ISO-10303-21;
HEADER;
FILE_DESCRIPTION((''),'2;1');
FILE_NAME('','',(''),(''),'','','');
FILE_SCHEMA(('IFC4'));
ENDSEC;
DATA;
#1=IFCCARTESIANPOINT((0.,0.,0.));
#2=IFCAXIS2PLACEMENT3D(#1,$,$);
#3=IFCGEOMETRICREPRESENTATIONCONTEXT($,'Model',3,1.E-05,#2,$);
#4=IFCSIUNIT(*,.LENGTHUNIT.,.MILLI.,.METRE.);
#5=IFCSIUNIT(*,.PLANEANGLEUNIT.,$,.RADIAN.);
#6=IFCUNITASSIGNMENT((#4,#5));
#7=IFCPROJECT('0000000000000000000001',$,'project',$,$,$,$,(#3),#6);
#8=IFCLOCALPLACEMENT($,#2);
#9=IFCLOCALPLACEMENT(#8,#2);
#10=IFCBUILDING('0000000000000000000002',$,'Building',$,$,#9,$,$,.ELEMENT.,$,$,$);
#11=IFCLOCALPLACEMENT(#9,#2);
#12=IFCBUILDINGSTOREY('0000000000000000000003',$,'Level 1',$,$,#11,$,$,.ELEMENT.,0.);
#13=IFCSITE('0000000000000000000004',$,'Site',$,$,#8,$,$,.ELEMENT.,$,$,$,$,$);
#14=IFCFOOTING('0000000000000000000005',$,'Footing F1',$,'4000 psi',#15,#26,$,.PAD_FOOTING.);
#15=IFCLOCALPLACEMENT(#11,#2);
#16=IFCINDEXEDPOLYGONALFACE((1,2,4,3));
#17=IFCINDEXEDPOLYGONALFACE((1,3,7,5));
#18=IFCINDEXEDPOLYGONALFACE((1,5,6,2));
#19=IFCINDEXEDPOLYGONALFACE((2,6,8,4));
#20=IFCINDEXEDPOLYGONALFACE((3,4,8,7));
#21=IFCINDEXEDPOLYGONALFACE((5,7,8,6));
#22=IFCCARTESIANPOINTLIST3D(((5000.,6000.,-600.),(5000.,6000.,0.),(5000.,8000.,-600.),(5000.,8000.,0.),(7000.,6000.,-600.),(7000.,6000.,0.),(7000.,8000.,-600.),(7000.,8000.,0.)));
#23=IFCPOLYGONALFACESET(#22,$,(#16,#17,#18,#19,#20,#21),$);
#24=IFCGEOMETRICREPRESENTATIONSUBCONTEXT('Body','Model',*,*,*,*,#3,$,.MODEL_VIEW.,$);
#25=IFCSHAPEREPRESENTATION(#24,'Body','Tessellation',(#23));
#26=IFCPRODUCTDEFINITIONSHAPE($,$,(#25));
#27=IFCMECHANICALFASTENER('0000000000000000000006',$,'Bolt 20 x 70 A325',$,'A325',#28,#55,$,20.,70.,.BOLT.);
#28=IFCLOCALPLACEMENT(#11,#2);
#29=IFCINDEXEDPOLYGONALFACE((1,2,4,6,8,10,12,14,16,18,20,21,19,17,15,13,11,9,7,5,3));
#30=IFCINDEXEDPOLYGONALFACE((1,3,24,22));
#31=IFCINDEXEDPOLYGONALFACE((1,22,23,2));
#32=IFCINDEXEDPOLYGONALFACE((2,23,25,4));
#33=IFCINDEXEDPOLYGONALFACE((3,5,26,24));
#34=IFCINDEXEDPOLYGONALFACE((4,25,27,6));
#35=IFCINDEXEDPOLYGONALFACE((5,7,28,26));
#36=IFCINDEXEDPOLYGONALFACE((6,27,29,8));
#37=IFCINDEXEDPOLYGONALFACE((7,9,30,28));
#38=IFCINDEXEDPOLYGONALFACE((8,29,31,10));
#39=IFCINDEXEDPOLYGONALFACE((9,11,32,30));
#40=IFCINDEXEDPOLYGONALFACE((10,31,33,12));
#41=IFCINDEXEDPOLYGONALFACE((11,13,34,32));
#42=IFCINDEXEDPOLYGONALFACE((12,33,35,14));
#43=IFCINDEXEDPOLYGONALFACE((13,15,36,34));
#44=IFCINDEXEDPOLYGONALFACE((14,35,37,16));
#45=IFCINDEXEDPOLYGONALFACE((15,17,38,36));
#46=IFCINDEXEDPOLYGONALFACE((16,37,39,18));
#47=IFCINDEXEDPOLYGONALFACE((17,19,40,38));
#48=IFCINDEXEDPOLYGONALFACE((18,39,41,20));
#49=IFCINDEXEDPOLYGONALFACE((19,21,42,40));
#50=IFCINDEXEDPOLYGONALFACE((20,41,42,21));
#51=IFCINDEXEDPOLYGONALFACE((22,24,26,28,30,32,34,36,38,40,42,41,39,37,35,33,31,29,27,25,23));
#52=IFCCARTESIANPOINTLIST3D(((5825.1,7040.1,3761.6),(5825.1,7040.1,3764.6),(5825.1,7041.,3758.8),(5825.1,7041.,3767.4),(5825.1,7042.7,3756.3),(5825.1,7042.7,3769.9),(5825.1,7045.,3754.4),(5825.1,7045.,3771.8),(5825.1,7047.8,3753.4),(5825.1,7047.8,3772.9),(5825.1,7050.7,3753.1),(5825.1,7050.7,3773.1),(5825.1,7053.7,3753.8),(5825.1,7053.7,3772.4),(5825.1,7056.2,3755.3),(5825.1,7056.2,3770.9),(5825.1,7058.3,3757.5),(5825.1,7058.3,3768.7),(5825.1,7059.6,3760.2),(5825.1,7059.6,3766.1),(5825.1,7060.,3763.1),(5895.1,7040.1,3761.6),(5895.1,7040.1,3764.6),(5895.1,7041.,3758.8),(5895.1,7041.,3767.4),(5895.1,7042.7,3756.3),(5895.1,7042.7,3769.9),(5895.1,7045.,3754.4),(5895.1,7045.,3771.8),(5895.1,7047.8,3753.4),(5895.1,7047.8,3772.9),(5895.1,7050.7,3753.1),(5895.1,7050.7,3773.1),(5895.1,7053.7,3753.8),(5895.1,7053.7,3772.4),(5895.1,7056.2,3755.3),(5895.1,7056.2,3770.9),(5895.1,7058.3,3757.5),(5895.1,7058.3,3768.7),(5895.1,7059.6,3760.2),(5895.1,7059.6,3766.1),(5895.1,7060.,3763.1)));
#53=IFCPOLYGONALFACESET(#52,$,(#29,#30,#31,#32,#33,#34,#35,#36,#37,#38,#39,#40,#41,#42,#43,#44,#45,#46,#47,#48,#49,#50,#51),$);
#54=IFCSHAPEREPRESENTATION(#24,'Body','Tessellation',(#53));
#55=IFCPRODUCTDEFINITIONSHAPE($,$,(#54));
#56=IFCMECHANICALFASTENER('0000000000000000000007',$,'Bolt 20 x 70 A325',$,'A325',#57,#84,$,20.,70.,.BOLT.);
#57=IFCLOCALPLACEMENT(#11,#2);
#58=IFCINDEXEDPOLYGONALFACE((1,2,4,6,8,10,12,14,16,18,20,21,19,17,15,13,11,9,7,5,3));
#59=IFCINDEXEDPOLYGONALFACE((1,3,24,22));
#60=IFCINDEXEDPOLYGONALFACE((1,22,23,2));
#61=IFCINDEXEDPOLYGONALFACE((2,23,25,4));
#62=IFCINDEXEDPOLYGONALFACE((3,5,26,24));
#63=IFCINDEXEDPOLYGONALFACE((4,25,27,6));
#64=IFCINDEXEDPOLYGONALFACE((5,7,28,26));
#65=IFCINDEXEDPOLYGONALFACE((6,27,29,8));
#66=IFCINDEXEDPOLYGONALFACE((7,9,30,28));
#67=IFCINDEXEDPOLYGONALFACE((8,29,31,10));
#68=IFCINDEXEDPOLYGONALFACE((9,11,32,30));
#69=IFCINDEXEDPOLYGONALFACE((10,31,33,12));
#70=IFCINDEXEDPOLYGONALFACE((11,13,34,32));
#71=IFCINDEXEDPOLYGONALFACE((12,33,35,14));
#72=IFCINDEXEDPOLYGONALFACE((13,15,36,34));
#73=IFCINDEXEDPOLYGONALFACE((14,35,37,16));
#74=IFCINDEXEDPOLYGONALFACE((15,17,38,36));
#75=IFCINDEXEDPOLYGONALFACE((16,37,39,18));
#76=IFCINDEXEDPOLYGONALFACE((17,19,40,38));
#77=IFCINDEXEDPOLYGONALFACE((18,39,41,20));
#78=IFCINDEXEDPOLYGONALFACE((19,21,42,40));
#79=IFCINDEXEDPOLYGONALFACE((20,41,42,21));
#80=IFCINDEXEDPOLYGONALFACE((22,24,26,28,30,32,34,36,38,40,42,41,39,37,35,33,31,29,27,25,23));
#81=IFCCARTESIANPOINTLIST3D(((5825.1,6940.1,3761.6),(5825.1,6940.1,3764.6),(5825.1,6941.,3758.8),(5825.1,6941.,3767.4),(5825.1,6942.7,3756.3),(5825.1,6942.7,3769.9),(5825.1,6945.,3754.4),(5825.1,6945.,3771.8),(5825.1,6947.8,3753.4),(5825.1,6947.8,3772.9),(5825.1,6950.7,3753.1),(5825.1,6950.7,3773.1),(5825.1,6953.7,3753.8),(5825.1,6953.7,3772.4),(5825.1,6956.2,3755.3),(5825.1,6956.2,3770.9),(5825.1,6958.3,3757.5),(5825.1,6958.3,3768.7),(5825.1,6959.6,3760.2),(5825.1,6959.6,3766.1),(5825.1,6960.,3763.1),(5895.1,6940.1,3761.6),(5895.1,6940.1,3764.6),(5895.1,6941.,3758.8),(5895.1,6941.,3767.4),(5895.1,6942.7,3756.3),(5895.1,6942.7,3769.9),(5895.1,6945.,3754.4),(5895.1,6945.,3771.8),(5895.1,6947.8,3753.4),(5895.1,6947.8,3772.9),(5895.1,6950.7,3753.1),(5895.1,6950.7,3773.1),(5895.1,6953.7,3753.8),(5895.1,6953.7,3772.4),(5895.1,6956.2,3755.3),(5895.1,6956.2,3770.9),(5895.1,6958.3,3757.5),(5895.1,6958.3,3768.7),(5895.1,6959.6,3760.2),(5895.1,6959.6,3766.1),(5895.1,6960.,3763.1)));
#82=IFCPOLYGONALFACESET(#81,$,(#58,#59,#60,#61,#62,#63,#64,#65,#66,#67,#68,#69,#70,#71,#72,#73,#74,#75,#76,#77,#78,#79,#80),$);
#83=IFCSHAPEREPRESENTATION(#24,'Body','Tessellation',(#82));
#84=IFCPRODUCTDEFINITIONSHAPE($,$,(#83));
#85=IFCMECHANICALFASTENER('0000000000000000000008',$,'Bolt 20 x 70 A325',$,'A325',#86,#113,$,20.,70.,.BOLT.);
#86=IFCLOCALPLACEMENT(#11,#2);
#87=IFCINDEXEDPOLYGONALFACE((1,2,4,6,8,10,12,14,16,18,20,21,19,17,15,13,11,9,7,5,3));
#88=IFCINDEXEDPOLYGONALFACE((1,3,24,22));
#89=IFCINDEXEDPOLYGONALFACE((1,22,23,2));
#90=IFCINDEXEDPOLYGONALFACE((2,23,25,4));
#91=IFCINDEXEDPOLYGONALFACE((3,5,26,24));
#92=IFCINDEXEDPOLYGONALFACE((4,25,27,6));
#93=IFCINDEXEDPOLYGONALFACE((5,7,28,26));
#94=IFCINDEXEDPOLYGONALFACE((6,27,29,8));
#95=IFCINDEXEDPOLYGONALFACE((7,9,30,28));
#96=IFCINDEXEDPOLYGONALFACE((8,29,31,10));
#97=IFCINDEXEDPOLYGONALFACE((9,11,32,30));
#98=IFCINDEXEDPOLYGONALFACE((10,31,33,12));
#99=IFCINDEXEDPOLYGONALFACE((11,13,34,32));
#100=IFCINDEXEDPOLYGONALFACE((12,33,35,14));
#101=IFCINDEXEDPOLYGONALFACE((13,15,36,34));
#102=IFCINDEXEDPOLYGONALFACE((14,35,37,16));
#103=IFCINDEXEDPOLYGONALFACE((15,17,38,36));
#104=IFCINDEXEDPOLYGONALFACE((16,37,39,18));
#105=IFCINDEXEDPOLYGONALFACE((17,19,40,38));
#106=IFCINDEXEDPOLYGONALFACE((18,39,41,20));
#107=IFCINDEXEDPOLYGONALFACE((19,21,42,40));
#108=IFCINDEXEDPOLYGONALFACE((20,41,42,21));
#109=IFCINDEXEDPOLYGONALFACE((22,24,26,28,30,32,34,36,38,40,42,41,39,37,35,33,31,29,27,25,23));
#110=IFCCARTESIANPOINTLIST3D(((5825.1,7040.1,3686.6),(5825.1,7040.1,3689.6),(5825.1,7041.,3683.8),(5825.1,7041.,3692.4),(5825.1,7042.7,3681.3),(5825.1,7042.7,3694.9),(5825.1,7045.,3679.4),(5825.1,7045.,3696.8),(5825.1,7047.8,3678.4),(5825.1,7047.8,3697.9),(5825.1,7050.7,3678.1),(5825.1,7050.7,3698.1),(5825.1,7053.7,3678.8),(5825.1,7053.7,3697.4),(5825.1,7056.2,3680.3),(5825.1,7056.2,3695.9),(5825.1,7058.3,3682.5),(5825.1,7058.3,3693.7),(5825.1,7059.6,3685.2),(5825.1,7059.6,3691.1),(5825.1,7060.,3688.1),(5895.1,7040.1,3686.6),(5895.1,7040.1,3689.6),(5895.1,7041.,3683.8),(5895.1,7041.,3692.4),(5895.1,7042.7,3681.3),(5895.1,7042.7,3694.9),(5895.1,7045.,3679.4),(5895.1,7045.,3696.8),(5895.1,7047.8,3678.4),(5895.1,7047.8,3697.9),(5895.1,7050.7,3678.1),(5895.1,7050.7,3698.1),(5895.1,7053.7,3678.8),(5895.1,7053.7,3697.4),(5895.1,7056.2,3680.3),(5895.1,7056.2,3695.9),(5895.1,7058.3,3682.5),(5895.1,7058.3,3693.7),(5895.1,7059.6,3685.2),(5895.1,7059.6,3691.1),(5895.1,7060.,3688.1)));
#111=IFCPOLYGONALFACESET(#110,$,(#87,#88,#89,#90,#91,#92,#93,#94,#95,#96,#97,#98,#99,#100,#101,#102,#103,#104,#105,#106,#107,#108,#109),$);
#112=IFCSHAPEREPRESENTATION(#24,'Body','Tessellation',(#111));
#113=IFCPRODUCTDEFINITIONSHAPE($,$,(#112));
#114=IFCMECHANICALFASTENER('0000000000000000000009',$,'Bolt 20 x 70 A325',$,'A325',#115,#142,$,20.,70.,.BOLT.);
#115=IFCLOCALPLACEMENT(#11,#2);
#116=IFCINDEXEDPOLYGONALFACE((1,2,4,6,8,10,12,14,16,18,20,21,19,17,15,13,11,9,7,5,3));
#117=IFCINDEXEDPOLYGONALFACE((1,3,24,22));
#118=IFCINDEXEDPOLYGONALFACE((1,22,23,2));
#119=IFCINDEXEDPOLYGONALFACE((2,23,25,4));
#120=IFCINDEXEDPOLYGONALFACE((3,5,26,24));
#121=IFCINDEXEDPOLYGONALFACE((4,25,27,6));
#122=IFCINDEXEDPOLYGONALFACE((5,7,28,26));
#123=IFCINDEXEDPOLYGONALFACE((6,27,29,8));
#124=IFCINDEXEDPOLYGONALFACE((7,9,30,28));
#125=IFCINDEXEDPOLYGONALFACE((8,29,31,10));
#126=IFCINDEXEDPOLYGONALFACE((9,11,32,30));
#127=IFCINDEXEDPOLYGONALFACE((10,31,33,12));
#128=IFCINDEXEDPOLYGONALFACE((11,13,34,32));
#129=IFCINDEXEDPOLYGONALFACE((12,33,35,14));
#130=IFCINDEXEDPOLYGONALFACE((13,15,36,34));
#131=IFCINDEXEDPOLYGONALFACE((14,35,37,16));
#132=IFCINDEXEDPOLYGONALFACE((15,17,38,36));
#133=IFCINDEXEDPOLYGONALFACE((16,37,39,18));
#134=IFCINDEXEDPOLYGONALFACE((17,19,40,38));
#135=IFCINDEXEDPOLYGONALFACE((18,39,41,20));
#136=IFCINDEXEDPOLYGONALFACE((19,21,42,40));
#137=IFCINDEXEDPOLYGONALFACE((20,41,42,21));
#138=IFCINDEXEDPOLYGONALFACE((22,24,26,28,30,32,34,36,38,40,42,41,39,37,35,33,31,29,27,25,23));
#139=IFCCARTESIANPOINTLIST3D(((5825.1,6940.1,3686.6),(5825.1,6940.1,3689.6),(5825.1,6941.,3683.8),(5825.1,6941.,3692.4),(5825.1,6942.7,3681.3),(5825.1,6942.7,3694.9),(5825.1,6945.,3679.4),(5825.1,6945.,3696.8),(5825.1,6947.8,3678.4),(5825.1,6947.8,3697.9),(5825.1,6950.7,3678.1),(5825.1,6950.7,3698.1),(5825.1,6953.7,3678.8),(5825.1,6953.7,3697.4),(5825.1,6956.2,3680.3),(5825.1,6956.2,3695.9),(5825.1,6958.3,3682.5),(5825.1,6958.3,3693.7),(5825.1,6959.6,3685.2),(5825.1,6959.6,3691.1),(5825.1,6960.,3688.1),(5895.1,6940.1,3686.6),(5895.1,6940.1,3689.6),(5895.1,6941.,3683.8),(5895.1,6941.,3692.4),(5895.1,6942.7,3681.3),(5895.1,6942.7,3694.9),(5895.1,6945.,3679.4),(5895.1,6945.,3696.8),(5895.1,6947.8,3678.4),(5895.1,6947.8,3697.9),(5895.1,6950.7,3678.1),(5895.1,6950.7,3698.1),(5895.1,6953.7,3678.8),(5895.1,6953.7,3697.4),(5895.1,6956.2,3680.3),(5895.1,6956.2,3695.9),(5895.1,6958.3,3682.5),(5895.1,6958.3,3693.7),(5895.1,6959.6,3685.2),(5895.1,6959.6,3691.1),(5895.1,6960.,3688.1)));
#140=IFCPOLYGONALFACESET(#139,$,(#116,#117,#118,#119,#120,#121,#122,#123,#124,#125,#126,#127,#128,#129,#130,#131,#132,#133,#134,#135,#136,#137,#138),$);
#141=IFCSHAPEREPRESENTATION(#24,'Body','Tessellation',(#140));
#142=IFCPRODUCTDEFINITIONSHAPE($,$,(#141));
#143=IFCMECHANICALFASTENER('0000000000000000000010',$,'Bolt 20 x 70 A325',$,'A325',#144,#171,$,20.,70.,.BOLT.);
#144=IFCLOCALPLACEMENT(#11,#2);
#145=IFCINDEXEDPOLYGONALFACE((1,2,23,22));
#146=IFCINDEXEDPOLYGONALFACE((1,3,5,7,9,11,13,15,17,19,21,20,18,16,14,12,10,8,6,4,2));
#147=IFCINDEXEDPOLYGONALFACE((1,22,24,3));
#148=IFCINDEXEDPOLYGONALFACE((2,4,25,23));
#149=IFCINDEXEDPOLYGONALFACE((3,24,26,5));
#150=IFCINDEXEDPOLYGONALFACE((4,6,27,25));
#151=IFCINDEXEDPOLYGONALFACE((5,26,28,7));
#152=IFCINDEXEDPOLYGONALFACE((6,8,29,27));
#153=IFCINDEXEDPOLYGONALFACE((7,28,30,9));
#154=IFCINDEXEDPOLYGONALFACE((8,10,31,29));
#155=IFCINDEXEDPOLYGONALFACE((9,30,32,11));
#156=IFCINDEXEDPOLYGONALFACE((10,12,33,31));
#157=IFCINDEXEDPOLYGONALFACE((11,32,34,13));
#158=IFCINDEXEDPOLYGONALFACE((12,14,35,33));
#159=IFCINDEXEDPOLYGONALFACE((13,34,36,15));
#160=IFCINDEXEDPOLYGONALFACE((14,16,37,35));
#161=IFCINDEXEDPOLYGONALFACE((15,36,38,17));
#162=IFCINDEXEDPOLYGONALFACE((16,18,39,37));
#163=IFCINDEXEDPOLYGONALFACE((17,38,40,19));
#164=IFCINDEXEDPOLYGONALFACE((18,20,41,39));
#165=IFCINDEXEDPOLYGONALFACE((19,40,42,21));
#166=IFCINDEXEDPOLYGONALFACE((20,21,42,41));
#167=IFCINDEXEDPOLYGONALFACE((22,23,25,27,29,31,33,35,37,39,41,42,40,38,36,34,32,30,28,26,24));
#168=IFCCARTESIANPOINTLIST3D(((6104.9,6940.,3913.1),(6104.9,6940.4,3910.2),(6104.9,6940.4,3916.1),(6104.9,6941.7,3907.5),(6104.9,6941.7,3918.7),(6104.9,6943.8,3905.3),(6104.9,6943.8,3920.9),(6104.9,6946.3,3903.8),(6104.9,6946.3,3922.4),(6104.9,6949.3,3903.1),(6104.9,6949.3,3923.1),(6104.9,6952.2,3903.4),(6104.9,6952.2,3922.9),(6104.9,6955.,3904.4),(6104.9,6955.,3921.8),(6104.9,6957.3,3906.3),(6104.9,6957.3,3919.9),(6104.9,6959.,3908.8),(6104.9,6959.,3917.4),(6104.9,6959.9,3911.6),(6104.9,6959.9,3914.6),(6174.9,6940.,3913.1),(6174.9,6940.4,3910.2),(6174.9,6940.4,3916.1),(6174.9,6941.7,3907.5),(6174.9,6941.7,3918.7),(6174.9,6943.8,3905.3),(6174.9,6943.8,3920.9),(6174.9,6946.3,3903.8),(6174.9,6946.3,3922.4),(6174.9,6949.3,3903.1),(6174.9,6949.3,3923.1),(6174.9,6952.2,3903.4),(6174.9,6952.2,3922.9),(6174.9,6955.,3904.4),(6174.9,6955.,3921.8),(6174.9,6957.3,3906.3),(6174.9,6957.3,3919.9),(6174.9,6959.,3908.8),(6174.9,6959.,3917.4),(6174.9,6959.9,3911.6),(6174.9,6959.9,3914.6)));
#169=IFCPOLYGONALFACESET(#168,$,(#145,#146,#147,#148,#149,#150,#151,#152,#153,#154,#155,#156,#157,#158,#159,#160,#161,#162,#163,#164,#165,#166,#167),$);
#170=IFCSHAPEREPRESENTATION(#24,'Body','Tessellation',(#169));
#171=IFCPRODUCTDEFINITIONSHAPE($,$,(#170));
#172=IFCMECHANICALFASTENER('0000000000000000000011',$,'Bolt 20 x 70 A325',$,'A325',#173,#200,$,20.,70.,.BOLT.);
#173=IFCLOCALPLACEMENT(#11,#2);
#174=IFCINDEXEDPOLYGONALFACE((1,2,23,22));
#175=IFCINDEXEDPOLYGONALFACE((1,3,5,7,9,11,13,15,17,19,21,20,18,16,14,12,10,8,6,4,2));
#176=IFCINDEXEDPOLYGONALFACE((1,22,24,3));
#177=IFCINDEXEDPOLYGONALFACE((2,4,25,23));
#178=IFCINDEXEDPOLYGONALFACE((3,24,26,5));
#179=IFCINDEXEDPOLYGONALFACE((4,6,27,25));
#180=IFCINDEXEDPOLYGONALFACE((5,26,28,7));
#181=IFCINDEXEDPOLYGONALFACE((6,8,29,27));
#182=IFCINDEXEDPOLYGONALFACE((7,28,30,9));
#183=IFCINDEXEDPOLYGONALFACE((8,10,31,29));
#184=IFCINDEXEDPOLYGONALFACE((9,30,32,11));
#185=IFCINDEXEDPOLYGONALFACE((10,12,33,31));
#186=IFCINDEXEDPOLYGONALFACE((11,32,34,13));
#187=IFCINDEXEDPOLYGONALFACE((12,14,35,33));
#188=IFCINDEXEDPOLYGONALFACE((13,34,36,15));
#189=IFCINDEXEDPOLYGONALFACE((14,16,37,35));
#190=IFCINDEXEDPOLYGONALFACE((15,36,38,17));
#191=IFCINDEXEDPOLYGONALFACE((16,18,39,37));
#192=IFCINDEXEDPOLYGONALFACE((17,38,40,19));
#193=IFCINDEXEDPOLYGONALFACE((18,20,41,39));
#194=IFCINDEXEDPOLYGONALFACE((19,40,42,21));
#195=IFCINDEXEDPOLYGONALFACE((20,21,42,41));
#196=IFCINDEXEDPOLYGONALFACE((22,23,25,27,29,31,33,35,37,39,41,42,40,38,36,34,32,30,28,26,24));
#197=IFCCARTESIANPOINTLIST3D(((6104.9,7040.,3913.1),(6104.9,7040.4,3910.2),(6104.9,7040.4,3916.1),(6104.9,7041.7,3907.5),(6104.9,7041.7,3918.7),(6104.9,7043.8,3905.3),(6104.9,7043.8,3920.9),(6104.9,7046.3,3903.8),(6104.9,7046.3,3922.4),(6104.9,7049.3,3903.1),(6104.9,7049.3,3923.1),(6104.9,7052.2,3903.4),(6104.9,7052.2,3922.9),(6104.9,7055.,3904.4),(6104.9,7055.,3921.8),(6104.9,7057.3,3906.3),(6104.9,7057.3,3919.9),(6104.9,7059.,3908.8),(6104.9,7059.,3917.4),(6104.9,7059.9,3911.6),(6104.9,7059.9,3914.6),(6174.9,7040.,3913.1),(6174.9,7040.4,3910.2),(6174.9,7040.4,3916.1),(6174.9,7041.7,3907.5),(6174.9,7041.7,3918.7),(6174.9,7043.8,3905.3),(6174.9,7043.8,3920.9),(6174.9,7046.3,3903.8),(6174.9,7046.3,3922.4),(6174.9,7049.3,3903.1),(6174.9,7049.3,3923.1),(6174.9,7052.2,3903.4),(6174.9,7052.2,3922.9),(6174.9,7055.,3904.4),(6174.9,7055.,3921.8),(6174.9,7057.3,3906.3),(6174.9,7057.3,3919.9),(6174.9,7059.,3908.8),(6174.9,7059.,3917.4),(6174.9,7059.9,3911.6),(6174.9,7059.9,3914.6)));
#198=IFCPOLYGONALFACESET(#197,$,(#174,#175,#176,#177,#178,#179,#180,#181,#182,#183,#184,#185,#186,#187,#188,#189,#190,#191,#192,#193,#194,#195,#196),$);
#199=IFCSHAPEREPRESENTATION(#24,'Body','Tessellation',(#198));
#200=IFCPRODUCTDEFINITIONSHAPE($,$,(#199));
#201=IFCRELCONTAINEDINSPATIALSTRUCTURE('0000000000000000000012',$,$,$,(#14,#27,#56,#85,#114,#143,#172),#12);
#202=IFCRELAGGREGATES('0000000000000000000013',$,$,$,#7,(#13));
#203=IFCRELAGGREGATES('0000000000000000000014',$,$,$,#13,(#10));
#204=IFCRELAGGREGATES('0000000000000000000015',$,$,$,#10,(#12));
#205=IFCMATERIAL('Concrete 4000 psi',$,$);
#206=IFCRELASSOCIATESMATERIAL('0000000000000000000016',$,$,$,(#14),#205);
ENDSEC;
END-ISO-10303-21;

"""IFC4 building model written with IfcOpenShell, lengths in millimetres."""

from ifc_helpers import new_model, si_unit, frame, origin, origin_2d, place, context, subcontext, project, spatial, rectangle, circle, extrude, material, element, save


model = new_model("IFC4")

# Units and contexts
model_context = context("Model", 3, precision=1e-05, world=origin())
body_context = subcontext(model_context, "Body", "Model", "MODEL_VIEW")
ifc_project = project(units=[si_unit("LENGTHUNIT", "METRE", prefix="MILLI"), si_unit("PLANEANGLEUNIT", "RADIAN")], contexts=[model_context])

# Site, building, storey
site_placement = place(None, origin())
site = spatial("IfcSite", under=ifc_project, at=site_placement, Name="Site", CompositionType="ELEMENT")
building_placement = place(site_placement, origin())
building = spatial("IfcBuilding", under=site, at=building_placement, Name="Building", CompositionType="ELEMENT")
storey_placement = place(building_placement, origin())
storey = spatial("IfcBuildingStorey", under=building, at=storey_placement, Name="Level 1", CompositionType="ELEMENT", Elevation=0.0)

# Footing
ifc_material_1 = material(Name="Concrete 4000 psi")
footing_placement = place(storey_placement, frame((6000.0, 7000.0, -600.0), z_axis=(0.0, 0.0, 1.0), x_axis=(1.0, 0.0, 0.0)))
element("IfcFooting", 1, at=footing_placement, inside=storey, material=ifc_material_1, Name="Footing F1", ObjectType="4000 psi", PredefinedType="PAD_FOOTING", context=body_context, shape_type="SweptSolid", body=[
    extrude(rectangle(XDim=2000.0, YDim=2000.0, at=origin_2d()), origin(), (0.0, 0.0, 1.0), 600.0),
])

# Mechanical fasteners
for number, where, z_axis, x_axis, name in (
    (2, (5825.1, 7050.0, 3763.1), (1.0, 0.0, 0.0), (0.0, 1.0, 0.0), "Bolt 20 x 70 A325"),
    (3, (5825.1, 6950.0, 3763.1), (1.0, 0.0, 0.0), (0.0, 1.0, 0.0), "Bolt 20 x 70 A325"),
    (4, (5825.1, 7050.0, 3688.1), (1.0, 0.0, 0.0), (0.0, 1.0, 0.0), "Bolt 20 x 70 A325"),
    (5, (5825.1, 6950.0, 3688.1), (1.0, 0.0, 0.0), (0.0, 1.0, 0.0), "Bolt 20 x 70 A325"),
    (6, (6174.9, 6950.0, 3913.1), (-1.0, 0.0, 0.0), (0.0, -1.0, 0.0), "Bolt 20 x 70 A325"),
    (7, (6174.9, 7050.0, 3913.1), (-1.0, 0.0, 0.0), (0.0, -1.0, 0.0), "Bolt 20 x 70 A325"),
):
    element("IfcMechanicalFastener", number, at=place(storey_placement, frame(where, z_axis=z_axis, x_axis=x_axis)), inside=storey, Name=name, ObjectType="A325", NominalDiameter=20.0, NominalLength=70.0, PredefinedType="BOLT", context=body_context, shape_type="SweptSolid", body=[
        extrude(circle(Radius=10.0, at=origin_2d()), origin(), (0.0, 0.0, 1.0), 70.0),
    ])

save(model, "model.ifc")
